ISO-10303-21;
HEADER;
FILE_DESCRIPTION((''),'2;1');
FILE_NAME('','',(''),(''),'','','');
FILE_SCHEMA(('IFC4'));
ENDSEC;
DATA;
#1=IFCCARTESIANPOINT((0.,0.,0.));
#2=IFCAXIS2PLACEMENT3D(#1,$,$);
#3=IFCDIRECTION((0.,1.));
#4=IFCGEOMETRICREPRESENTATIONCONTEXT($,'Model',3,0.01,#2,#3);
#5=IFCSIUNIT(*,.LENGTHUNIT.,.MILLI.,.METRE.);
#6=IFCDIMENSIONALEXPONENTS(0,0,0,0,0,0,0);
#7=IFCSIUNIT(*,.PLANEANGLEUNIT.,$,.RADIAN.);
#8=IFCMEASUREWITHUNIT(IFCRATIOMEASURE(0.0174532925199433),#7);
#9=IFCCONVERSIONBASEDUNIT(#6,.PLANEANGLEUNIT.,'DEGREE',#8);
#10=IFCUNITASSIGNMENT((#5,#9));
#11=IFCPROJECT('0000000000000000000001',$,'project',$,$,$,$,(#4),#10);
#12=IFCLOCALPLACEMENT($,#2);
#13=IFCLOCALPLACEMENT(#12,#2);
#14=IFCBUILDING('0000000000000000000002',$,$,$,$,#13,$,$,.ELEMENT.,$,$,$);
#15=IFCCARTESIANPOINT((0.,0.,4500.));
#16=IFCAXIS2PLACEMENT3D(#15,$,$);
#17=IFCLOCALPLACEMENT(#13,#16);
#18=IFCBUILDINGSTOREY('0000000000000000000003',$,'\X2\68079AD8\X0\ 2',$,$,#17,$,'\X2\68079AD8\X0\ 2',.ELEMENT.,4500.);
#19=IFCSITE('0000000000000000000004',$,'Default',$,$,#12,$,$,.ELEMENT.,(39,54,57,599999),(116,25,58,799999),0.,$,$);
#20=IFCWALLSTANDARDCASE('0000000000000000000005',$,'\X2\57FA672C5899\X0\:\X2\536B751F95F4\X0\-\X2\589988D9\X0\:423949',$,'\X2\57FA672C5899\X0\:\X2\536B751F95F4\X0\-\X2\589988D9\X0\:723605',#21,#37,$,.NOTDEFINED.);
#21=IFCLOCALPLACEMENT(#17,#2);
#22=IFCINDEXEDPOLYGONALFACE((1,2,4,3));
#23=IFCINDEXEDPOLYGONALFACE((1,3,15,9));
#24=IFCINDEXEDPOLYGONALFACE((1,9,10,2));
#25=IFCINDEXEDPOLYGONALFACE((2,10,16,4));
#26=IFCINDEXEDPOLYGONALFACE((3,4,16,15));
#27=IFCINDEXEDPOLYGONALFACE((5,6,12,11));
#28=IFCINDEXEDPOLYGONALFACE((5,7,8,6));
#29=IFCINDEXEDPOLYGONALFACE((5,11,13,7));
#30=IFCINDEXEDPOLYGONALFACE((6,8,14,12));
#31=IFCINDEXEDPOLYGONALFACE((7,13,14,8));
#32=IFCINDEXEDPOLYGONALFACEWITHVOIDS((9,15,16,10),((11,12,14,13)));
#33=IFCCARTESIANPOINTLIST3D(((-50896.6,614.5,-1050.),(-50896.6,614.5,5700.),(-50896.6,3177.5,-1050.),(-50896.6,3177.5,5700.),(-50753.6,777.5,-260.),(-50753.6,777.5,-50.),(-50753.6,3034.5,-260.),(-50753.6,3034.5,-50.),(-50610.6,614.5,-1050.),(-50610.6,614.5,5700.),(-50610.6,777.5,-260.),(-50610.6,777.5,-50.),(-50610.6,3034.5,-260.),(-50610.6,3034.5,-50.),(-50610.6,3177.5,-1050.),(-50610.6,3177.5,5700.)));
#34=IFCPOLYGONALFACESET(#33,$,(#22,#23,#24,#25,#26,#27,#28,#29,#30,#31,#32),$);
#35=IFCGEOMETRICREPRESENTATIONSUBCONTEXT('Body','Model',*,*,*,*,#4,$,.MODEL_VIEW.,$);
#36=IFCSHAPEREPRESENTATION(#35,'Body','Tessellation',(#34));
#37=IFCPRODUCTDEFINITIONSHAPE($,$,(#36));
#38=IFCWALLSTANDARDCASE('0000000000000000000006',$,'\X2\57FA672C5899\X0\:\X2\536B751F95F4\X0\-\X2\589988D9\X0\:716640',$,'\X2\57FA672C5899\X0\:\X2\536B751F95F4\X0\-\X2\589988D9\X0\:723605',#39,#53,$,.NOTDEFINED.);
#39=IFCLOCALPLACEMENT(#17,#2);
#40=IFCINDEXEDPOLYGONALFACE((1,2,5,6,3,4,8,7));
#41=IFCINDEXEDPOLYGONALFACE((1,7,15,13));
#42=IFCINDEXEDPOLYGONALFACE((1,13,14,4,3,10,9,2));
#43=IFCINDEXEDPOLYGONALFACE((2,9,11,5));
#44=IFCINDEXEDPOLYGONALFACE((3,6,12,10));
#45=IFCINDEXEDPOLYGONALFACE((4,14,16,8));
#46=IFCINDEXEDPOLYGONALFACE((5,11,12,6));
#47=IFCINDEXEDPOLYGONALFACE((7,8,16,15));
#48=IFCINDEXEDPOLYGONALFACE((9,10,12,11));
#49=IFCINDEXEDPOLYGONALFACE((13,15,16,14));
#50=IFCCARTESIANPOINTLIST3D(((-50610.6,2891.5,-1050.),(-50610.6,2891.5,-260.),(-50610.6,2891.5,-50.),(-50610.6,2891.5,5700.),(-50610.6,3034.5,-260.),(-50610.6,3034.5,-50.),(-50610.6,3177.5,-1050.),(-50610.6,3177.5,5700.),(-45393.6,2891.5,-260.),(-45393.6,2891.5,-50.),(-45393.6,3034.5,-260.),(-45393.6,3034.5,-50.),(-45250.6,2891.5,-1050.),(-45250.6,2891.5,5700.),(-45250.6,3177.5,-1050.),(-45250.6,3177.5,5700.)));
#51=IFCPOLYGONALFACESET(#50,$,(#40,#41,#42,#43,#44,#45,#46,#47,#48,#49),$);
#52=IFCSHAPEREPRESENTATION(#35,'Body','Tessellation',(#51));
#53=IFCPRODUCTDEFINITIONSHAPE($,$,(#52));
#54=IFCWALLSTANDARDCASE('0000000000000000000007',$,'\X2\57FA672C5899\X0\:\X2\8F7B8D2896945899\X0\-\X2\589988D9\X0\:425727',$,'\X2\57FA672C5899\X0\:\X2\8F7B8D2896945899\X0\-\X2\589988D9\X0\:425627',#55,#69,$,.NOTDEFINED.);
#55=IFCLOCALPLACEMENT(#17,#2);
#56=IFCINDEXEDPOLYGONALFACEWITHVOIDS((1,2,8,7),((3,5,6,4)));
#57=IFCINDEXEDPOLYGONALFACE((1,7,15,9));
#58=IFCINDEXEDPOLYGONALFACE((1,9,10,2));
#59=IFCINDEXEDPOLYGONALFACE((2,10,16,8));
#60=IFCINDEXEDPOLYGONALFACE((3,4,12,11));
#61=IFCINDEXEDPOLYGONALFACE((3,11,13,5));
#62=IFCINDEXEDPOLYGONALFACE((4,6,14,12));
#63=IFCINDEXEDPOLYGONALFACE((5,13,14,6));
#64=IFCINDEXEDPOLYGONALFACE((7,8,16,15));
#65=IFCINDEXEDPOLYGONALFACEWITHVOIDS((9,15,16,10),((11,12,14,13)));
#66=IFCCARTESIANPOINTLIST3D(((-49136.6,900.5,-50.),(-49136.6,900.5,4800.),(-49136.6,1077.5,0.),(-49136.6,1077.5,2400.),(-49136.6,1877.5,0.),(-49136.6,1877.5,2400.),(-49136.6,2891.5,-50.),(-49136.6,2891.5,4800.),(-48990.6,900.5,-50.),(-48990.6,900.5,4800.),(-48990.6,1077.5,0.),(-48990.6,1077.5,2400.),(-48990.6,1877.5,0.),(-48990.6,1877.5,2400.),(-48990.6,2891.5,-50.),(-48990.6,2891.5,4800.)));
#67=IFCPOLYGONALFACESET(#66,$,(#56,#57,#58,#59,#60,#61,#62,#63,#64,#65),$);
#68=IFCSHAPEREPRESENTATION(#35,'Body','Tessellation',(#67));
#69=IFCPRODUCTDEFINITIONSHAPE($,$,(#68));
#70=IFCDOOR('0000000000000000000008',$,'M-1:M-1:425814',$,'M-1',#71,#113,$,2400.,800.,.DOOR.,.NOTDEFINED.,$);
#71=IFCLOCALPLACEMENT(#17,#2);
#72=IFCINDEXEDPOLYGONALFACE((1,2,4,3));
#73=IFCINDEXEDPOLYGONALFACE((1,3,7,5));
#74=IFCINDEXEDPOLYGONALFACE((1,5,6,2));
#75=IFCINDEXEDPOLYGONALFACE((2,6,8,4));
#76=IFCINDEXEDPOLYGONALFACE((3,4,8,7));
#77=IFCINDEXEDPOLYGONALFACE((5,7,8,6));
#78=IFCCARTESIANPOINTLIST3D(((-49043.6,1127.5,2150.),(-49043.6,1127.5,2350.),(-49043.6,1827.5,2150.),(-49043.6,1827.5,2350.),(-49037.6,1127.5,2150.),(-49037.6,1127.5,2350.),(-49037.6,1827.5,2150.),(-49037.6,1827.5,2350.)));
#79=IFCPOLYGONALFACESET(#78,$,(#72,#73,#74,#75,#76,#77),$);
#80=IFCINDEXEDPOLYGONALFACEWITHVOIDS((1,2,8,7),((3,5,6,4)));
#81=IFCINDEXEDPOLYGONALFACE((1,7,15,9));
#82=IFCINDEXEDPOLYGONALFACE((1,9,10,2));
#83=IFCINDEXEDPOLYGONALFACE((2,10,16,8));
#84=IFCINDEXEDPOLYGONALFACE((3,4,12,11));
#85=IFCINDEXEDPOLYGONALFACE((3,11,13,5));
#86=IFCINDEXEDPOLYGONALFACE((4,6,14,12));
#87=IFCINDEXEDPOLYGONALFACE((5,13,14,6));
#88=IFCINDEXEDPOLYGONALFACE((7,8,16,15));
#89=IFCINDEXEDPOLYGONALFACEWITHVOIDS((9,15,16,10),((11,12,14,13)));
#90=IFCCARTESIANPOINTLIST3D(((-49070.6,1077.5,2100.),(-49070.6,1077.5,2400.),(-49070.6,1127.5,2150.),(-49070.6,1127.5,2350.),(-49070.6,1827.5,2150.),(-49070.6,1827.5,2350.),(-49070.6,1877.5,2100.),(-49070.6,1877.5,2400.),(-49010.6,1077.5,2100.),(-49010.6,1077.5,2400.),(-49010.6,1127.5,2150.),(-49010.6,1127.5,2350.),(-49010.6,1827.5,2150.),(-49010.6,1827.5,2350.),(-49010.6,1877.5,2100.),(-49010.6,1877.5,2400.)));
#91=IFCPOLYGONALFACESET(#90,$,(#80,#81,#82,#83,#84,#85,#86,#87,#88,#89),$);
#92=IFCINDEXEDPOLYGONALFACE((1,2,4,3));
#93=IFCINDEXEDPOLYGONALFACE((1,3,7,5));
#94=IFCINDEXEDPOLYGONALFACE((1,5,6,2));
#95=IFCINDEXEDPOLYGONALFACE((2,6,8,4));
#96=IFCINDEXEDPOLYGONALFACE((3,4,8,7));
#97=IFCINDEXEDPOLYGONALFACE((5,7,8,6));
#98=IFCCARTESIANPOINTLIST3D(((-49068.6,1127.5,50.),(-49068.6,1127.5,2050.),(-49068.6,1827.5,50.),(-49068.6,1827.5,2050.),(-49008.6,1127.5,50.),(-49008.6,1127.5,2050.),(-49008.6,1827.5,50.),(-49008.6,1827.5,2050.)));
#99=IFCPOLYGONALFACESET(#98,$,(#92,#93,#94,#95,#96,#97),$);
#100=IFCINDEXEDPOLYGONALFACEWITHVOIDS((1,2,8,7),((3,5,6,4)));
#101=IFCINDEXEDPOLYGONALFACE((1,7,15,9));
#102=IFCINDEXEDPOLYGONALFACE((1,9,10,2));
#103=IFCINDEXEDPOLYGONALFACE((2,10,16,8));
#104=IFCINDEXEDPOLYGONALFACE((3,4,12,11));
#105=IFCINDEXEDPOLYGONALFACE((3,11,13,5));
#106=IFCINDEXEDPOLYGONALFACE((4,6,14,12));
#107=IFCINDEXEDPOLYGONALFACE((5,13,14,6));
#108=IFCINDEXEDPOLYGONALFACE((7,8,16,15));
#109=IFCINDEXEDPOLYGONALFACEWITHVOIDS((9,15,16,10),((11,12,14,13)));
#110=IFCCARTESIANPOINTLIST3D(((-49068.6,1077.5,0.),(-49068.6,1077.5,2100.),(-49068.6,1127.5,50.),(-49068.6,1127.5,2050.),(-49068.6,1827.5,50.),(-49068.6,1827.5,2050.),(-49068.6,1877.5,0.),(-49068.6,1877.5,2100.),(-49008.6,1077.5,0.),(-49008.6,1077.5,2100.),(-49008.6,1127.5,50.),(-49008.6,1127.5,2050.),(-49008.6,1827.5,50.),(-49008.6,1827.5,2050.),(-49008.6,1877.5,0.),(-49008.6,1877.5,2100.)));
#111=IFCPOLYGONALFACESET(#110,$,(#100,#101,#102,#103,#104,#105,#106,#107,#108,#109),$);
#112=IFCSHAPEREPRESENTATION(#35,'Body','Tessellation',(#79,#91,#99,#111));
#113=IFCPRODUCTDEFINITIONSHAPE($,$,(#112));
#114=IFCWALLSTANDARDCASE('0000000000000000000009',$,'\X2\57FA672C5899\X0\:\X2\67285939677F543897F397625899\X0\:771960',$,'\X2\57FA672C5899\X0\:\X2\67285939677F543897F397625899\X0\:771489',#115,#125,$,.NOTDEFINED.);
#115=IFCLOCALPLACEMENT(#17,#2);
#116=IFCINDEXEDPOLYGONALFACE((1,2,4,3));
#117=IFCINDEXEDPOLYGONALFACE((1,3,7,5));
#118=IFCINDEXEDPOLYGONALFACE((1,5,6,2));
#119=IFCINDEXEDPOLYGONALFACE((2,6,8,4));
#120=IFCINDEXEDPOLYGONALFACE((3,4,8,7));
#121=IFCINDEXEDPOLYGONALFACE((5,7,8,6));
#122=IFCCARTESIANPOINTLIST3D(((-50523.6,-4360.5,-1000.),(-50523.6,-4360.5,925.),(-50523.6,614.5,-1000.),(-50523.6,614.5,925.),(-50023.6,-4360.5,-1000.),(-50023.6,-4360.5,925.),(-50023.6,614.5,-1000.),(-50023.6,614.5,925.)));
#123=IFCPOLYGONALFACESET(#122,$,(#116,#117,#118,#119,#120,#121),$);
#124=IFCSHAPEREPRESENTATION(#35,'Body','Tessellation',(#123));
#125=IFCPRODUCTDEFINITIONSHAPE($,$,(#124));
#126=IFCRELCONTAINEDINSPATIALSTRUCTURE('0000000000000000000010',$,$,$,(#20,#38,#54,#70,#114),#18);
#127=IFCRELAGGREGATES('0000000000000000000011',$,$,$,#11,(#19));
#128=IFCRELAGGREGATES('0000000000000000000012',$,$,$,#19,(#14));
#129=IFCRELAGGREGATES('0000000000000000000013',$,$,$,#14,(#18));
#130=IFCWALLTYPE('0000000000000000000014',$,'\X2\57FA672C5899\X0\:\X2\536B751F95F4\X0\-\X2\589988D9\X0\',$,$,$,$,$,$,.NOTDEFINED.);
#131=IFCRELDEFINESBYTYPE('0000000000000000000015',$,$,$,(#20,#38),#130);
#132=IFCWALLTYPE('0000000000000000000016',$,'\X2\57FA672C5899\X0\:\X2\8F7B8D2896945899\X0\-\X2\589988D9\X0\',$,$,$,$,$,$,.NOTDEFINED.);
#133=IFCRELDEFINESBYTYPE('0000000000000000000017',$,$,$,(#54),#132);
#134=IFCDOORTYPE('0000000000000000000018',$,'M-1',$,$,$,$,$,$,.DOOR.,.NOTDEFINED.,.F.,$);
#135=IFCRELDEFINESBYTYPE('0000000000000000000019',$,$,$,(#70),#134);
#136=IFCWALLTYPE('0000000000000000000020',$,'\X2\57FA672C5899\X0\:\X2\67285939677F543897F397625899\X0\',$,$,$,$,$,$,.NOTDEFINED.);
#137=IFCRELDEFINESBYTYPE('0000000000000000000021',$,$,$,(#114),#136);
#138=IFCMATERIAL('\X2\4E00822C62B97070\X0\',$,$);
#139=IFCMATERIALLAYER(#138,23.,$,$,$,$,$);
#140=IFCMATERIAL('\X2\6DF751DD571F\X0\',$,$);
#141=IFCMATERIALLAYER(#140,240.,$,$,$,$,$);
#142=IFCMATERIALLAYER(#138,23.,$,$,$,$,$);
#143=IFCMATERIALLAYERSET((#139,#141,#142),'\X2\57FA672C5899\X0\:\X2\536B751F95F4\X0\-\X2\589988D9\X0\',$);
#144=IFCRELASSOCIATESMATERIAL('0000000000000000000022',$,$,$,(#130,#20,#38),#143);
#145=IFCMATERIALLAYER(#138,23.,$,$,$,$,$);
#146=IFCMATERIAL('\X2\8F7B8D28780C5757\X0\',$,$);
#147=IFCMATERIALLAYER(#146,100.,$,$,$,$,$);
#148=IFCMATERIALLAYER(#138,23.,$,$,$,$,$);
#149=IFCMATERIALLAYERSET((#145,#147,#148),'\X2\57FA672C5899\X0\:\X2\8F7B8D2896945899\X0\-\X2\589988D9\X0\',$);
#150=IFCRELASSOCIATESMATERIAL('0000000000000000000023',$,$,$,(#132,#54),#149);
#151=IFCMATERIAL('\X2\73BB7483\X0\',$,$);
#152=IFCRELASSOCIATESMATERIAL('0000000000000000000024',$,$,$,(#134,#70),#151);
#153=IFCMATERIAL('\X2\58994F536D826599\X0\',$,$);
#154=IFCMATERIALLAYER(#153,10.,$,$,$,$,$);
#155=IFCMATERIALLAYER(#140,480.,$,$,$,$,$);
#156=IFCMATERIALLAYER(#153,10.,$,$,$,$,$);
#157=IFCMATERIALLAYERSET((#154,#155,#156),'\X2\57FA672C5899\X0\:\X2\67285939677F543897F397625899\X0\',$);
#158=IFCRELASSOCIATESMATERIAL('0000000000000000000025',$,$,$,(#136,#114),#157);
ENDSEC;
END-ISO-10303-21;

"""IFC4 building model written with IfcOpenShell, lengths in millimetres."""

from ifc_helpers import new_model, entity, si_unit, converted_unit, direction, frame, frame_2d, origin, place, context, subcontext, project, spatial, polyline, rectangle, outline, extrude, source, transform, mapped, material, layer, layer_set, layer_usage, type_object, type_shapes, element, fill, save


model = new_model("IFC4")

# Units and contexts
model_context = context("Model", 3, precision=0.01, world=origin(), true_north=direction((0.0, 1.0)))
body_context = subcontext(model_context, "Body", "Model", "MODEL_VIEW")
ifc_project = project(units=[si_unit("LENGTHUNIT", "METRE", prefix="MILLI"), converted_unit("PLANEANGLEUNIT", "DEGREE", entity("IfcRatioMeasure", 0.0174532925199433), si_unit("PLANEANGLEUNIT", "RADIAN"), dimensions=[0, 0, 0, 0, 0, 0, 0])], contexts=[model_context])

# Site, building, storey
site_placement = place(None, origin())
site = spatial("IfcSite", under=ifc_project, at=site_placement, Name="Default", CompositionType="ELEMENT", RefLatitude=(39, 54, 57, 599999), RefLongitude=(116, 25, 58, 799999), RefElevation=0.0)
building_placement = place(site_placement, origin())
building = spatial("IfcBuilding", under=site, at=building_placement, CompositionType="ELEMENT")
storey_placement = place(building_placement, frame((0.0, 0.0, 4500.0)))
storey = spatial("IfcBuildingStorey", under=building, at=storey_placement, Name="标高 2", LongName="标高 2", CompositionType="ELEMENT", Elevation=4500.0)

# Walls, openings
ifc_material_1 = material(Name="一般抹灰")
ifc_layer_1 = layer(ifc_material_1, 23.0)
ifc_material_2 = material(Name="混凝土")
ifc_layer_2 = layer(ifc_material_2, 240.0)
ifc_layer_3 = layer(ifc_material_1, 23.0)
ifc_layer_set_1 = layer_set([ifc_layer_1, ifc_layer_2, ifc_layer_3], Name="基本墙:卫生间-墙裙")
ifc_layer_usage_1 = layer_usage(ifc_layer_set_1, "AXIS2", "NEGATIVE", 143.0)
wall_type_1 = type_object("IfcWallType", Name="基本墙:卫生间-墙裙", PredefinedType="NOTDEFINED", material=ifc_layer_set_1)
wall_1_placement = place(storey_placement, frame((-50753.6, 614.5, -1050.0), z_axis=(0.0, 0.0, 1.0), x_axis=(0.0, 1.0, 0.0)))
wall_1 = element("IfcWallStandardCase", 1, at=wall_1_placement, inside=storey, type_object=wall_type_1, material=ifc_layer_usage_1, Name="基本墙:卫生间-墙裙:423949", ObjectType="基本墙:卫生间-墙裙:723605", PredefinedType="NOTDEFINED", context=body_context, shape_type="SweptSolid", body=[
    extrude(rectangle(XDim=2563.0, YDim=286.0, at=frame_2d((1281.5, 0.0), x_axis=(-1.0, 0.0))), origin(), (0.0, 0.0, 1.0), 6750.0),
])
opening_1_placement = place(storey_placement, frame((-50753.6, 614.5, -1050.0), z_axis=(0.0, 0.0, 1.0), x_axis=(0.0, 1.0, 0.0)))
element("IfcOpeningElement", 2, at=opening_1_placement, cuts=wall_1, ObjectType="Opening", PredefinedType="OPENING", context=body_context, shape_type="SweptSolid", body=[
    extrude(rectangle(XDim=2257.0, YDim=143.0, at=frame_2d((-3.3, -23.8), x_axis=(1.0, 0.0))), frame((1288.2, -95.3, 790.0), z_axis=(0.0, 0.0, 1.0), x_axis=(-1.0, 0.0, 0.0)), (0.0, 0.0, 1.0), 210.0),
])
ifc_layer_usage_2 = layer_usage(ifc_layer_set_1, "AXIS2", "NEGATIVE", 143.0)
wall_2_placement = place(storey_placement, frame((-50610.6, 3034.5, -1050.0)))
wall_2 = element("IfcWallStandardCase", 3, at=wall_2_placement, inside=storey, type_object=wall_type_1, material=ifc_layer_usage_2, Name="基本墙:卫生间-墙裙:716640", ObjectType="基本墙:卫生间-墙裙:723605", PredefinedType="NOTDEFINED", context=body_context, shape_type="SweptSolid", body=[
    extrude(rectangle(XDim=5360.0, YDim=286.0, at=frame_2d((2680.0, 0.0), x_axis=(-1.0, 0.0))), origin(), (0.0, 0.0, 1.0), 6750.0),
])
opening_2_placement = place(storey_placement, frame((-50610.6, 3034.5, -1050.0)))
element("IfcOpeningElement", 4, at=opening_2_placement, cuts=wall_2, ObjectType="Opening", PredefinedType="OPENING", context=body_context, shape_type="SweptSolid", body=[
    extrude(rectangle(XDim=5217.0, YDim=143.0, at=frame_2d((493.1, -14.3), x_axis=(1.0, 0.0))), frame((3101.6, -85.8, 790.0), z_axis=(0.0, 0.0, 1.0), x_axis=(-1.0, 0.0, 0.0)), (0.0, 0.0, 1.0), 210.0),
])

# Wall, opening, door
ifc_layer_4 = layer(ifc_material_1, 23.0)
ifc_material_3 = material(Name="轻质砌块")
ifc_layer_5 = layer(ifc_material_3, 100.0)
ifc_layer_6 = layer(ifc_material_1, 23.0)
ifc_layer_set_2 = layer_set([ifc_layer_4, ifc_layer_5, ifc_layer_6], Name="基本墙:轻质隔墙-墙裙")
ifc_layer_usage_3 = layer_usage(ifc_layer_set_2, "AXIS2", "POSITIVE", -73.0)
wall_type_2 = type_object("IfcWallType", Name="基本墙:轻质隔墙-墙裙", PredefinedType="NOTDEFINED", material=ifc_layer_set_2)
wall_3_placement = place(storey_placement, frame((-49063.6, 900.5, -50.0), z_axis=(0.0, 0.0, 1.0), x_axis=(0.0, 1.0, 0.0)))
wall_3 = element("IfcWallStandardCase", 5, at=wall_3_placement, inside=storey, type_object=wall_type_2, material=ifc_layer_usage_3, Name="基本墙:轻质隔墙-墙裙:425727", ObjectType="基本墙:轻质隔墙-墙裙:425627", PredefinedType="NOTDEFINED", context=body_context, shape_type="SweptSolid", body=[
    extrude(rectangle(XDim=1991.0, YDim=146.0, at=frame_2d((995.5, 0.0), x_axis=(-1.0, 0.0))), origin(), (0.0, 0.0, 1.0), 4850.0),
])
opening_3_placement = place(wall_3_placement, frame((177.0, -73.0, 50.0)))
opening_3 = element("IfcOpeningElement", 6, at=opening_3_placement, cuts=wall_3, ObjectType="Opening", PredefinedType="OPENING", context=body_context, shape_type="SweptSolid", body=[
    extrude(rectangle(XDim=2400.0, YDim=800.0, at=frame_2d((1200.0, 400.0), x_axis=(1.0, 0.0))), frame((0.0, 0.0, 0.0), z_axis=(0.0, 1.0, 0.0), x_axis=(0.0, 0.0, 1.0)), (0.0, 0.0, 1.0), 146.0),
])
ifc_material_4 = material(Name="玻璃")
door_type = type_object("IfcDoorType", Name="M-1", OperationType="NOTDEFINED", ParameterTakesPrecedence=False, PredefinedType="DOOR", material=ifc_material_4)
shared_shape_1 = source(origin(), body_context, "Body", "SweptSolid", [
    extrude(rectangle(XDim=6.0, YDim=700.0, at=frame_2d((0.0, 0.0), x_axis=(1.0, 0.0))), frame((400.0, 50.0, 2150.0), z_axis=(0.0, 0.0, 1.0), x_axis=(0.0, -1.0, 0.0)), (0.0, 0.0, 1.0), 200.0),
    extrude(outline(polyline([(-400.0, -150.0), (400.0, -150.0), (400.0, 150.0), (-400.0, 150.0), (-400.0, -150.0)]), holes=[polyline([(-350.0, -100.0), (-350.0, 100.0), (350.0, 100.0), (350.0, -100.0), (-350.0, -100.0)])]), frame((400.0, 20.0, 2250.0), z_axis=(0.0, 1.0, 0.0), x_axis=(1.0, 0.0, 0.0)), (0.0, 0.0, 1.0), 60.0),
    extrude(rectangle(XDim=700.0, YDim=60.0, at=frame_2d((0.0, 0.0), x_axis=(1.0, 0.0))), frame((400.0, 48.0, 50.0), z_axis=(0.0, 0.0, 1.0), x_axis=(-1.0, 0.0, 0.0)), (0.0, 0.0, 1.0), 2000.0),
    extrude(outline(polyline([(-1050.0, -400.0), (1050.0, -400.0), (1050.0, 400.0), (-1050.0, 400.0), (-1050.0, -400.0)]), holes=[polyline([(-1000.0, 350.0), (1000.0, 350.0), (1000.0, -350.0), (-1000.0, -350.0), (-1000.0, 350.0)])]), frame((400.0, 18.0, 1050.0), z_axis=(0.0, 1.0, 0.0), x_axis=(0.0, 0.0, -1.0)), (0.0, 0.0, 1.0), 60.0),
])
type_shapes(door_type, [shared_shape_1])
door_placement = place(opening_3_placement, origin())
door = element("IfcDoor", 7, at=door_placement, inside=storey, type_object=door_type, material=ifc_material_4, Name="M-1:M-1:425814", ObjectType="M-1", OperationType="NOTDEFINED", OverallHeight=2400.0, OverallWidth=800.0, PredefinedType="DOOR", context=body_context, shape_type="MappedRepresentation", body=[
    mapped(shared_shape_1, transform((0.0, 0.0, 0.0), scale=1.0)),
])
fill(opening_3, door)

# Wall
ifc_material_5 = material(Name="墙体涂料")
ifc_layer_7 = layer(ifc_material_5, 10.0)
ifc_layer_8 = layer(ifc_material_2, 480.0)
ifc_layer_9 = layer(ifc_material_5, 10.0)
ifc_layer_set_3 = layer_set([ifc_layer_7, ifc_layer_8, ifc_layer_9], Name="基本墙:木夹板吸音面墙")
ifc_layer_usage_4 = layer_usage(ifc_layer_set_3, "AXIS2", "POSITIVE", -250.0)
wall_type_3 = type_object("IfcWallType", Name="基本墙:木夹板吸音面墙", PredefinedType="NOTDEFINED", material=ifc_layer_set_3)
wall_4_placement = place(storey_placement, frame((-50273.6, 614.5, -1000.0), z_axis=(0.0, 0.0, 1.0), x_axis=(0.0, -1.0, 0.0)))
element("IfcWallStandardCase", 8, at=wall_4_placement, inside=storey, type_object=wall_type_3, material=ifc_layer_usage_4, Name="基本墙:木夹板吸音面墙:771960", ObjectType="基本墙:木夹板吸音面墙:771489", PredefinedType="NOTDEFINED", context=body_context, shape_type="SweptSolid", body=[
    extrude(rectangle(XDim=4975.0, YDim=500.0, at=frame_2d((2487.5, 0.0), x_axis=(-1.0, 0.0))), origin(), (0.0, 0.0, 1.0), 1925.0),
])

save(model, "model.ifc")
